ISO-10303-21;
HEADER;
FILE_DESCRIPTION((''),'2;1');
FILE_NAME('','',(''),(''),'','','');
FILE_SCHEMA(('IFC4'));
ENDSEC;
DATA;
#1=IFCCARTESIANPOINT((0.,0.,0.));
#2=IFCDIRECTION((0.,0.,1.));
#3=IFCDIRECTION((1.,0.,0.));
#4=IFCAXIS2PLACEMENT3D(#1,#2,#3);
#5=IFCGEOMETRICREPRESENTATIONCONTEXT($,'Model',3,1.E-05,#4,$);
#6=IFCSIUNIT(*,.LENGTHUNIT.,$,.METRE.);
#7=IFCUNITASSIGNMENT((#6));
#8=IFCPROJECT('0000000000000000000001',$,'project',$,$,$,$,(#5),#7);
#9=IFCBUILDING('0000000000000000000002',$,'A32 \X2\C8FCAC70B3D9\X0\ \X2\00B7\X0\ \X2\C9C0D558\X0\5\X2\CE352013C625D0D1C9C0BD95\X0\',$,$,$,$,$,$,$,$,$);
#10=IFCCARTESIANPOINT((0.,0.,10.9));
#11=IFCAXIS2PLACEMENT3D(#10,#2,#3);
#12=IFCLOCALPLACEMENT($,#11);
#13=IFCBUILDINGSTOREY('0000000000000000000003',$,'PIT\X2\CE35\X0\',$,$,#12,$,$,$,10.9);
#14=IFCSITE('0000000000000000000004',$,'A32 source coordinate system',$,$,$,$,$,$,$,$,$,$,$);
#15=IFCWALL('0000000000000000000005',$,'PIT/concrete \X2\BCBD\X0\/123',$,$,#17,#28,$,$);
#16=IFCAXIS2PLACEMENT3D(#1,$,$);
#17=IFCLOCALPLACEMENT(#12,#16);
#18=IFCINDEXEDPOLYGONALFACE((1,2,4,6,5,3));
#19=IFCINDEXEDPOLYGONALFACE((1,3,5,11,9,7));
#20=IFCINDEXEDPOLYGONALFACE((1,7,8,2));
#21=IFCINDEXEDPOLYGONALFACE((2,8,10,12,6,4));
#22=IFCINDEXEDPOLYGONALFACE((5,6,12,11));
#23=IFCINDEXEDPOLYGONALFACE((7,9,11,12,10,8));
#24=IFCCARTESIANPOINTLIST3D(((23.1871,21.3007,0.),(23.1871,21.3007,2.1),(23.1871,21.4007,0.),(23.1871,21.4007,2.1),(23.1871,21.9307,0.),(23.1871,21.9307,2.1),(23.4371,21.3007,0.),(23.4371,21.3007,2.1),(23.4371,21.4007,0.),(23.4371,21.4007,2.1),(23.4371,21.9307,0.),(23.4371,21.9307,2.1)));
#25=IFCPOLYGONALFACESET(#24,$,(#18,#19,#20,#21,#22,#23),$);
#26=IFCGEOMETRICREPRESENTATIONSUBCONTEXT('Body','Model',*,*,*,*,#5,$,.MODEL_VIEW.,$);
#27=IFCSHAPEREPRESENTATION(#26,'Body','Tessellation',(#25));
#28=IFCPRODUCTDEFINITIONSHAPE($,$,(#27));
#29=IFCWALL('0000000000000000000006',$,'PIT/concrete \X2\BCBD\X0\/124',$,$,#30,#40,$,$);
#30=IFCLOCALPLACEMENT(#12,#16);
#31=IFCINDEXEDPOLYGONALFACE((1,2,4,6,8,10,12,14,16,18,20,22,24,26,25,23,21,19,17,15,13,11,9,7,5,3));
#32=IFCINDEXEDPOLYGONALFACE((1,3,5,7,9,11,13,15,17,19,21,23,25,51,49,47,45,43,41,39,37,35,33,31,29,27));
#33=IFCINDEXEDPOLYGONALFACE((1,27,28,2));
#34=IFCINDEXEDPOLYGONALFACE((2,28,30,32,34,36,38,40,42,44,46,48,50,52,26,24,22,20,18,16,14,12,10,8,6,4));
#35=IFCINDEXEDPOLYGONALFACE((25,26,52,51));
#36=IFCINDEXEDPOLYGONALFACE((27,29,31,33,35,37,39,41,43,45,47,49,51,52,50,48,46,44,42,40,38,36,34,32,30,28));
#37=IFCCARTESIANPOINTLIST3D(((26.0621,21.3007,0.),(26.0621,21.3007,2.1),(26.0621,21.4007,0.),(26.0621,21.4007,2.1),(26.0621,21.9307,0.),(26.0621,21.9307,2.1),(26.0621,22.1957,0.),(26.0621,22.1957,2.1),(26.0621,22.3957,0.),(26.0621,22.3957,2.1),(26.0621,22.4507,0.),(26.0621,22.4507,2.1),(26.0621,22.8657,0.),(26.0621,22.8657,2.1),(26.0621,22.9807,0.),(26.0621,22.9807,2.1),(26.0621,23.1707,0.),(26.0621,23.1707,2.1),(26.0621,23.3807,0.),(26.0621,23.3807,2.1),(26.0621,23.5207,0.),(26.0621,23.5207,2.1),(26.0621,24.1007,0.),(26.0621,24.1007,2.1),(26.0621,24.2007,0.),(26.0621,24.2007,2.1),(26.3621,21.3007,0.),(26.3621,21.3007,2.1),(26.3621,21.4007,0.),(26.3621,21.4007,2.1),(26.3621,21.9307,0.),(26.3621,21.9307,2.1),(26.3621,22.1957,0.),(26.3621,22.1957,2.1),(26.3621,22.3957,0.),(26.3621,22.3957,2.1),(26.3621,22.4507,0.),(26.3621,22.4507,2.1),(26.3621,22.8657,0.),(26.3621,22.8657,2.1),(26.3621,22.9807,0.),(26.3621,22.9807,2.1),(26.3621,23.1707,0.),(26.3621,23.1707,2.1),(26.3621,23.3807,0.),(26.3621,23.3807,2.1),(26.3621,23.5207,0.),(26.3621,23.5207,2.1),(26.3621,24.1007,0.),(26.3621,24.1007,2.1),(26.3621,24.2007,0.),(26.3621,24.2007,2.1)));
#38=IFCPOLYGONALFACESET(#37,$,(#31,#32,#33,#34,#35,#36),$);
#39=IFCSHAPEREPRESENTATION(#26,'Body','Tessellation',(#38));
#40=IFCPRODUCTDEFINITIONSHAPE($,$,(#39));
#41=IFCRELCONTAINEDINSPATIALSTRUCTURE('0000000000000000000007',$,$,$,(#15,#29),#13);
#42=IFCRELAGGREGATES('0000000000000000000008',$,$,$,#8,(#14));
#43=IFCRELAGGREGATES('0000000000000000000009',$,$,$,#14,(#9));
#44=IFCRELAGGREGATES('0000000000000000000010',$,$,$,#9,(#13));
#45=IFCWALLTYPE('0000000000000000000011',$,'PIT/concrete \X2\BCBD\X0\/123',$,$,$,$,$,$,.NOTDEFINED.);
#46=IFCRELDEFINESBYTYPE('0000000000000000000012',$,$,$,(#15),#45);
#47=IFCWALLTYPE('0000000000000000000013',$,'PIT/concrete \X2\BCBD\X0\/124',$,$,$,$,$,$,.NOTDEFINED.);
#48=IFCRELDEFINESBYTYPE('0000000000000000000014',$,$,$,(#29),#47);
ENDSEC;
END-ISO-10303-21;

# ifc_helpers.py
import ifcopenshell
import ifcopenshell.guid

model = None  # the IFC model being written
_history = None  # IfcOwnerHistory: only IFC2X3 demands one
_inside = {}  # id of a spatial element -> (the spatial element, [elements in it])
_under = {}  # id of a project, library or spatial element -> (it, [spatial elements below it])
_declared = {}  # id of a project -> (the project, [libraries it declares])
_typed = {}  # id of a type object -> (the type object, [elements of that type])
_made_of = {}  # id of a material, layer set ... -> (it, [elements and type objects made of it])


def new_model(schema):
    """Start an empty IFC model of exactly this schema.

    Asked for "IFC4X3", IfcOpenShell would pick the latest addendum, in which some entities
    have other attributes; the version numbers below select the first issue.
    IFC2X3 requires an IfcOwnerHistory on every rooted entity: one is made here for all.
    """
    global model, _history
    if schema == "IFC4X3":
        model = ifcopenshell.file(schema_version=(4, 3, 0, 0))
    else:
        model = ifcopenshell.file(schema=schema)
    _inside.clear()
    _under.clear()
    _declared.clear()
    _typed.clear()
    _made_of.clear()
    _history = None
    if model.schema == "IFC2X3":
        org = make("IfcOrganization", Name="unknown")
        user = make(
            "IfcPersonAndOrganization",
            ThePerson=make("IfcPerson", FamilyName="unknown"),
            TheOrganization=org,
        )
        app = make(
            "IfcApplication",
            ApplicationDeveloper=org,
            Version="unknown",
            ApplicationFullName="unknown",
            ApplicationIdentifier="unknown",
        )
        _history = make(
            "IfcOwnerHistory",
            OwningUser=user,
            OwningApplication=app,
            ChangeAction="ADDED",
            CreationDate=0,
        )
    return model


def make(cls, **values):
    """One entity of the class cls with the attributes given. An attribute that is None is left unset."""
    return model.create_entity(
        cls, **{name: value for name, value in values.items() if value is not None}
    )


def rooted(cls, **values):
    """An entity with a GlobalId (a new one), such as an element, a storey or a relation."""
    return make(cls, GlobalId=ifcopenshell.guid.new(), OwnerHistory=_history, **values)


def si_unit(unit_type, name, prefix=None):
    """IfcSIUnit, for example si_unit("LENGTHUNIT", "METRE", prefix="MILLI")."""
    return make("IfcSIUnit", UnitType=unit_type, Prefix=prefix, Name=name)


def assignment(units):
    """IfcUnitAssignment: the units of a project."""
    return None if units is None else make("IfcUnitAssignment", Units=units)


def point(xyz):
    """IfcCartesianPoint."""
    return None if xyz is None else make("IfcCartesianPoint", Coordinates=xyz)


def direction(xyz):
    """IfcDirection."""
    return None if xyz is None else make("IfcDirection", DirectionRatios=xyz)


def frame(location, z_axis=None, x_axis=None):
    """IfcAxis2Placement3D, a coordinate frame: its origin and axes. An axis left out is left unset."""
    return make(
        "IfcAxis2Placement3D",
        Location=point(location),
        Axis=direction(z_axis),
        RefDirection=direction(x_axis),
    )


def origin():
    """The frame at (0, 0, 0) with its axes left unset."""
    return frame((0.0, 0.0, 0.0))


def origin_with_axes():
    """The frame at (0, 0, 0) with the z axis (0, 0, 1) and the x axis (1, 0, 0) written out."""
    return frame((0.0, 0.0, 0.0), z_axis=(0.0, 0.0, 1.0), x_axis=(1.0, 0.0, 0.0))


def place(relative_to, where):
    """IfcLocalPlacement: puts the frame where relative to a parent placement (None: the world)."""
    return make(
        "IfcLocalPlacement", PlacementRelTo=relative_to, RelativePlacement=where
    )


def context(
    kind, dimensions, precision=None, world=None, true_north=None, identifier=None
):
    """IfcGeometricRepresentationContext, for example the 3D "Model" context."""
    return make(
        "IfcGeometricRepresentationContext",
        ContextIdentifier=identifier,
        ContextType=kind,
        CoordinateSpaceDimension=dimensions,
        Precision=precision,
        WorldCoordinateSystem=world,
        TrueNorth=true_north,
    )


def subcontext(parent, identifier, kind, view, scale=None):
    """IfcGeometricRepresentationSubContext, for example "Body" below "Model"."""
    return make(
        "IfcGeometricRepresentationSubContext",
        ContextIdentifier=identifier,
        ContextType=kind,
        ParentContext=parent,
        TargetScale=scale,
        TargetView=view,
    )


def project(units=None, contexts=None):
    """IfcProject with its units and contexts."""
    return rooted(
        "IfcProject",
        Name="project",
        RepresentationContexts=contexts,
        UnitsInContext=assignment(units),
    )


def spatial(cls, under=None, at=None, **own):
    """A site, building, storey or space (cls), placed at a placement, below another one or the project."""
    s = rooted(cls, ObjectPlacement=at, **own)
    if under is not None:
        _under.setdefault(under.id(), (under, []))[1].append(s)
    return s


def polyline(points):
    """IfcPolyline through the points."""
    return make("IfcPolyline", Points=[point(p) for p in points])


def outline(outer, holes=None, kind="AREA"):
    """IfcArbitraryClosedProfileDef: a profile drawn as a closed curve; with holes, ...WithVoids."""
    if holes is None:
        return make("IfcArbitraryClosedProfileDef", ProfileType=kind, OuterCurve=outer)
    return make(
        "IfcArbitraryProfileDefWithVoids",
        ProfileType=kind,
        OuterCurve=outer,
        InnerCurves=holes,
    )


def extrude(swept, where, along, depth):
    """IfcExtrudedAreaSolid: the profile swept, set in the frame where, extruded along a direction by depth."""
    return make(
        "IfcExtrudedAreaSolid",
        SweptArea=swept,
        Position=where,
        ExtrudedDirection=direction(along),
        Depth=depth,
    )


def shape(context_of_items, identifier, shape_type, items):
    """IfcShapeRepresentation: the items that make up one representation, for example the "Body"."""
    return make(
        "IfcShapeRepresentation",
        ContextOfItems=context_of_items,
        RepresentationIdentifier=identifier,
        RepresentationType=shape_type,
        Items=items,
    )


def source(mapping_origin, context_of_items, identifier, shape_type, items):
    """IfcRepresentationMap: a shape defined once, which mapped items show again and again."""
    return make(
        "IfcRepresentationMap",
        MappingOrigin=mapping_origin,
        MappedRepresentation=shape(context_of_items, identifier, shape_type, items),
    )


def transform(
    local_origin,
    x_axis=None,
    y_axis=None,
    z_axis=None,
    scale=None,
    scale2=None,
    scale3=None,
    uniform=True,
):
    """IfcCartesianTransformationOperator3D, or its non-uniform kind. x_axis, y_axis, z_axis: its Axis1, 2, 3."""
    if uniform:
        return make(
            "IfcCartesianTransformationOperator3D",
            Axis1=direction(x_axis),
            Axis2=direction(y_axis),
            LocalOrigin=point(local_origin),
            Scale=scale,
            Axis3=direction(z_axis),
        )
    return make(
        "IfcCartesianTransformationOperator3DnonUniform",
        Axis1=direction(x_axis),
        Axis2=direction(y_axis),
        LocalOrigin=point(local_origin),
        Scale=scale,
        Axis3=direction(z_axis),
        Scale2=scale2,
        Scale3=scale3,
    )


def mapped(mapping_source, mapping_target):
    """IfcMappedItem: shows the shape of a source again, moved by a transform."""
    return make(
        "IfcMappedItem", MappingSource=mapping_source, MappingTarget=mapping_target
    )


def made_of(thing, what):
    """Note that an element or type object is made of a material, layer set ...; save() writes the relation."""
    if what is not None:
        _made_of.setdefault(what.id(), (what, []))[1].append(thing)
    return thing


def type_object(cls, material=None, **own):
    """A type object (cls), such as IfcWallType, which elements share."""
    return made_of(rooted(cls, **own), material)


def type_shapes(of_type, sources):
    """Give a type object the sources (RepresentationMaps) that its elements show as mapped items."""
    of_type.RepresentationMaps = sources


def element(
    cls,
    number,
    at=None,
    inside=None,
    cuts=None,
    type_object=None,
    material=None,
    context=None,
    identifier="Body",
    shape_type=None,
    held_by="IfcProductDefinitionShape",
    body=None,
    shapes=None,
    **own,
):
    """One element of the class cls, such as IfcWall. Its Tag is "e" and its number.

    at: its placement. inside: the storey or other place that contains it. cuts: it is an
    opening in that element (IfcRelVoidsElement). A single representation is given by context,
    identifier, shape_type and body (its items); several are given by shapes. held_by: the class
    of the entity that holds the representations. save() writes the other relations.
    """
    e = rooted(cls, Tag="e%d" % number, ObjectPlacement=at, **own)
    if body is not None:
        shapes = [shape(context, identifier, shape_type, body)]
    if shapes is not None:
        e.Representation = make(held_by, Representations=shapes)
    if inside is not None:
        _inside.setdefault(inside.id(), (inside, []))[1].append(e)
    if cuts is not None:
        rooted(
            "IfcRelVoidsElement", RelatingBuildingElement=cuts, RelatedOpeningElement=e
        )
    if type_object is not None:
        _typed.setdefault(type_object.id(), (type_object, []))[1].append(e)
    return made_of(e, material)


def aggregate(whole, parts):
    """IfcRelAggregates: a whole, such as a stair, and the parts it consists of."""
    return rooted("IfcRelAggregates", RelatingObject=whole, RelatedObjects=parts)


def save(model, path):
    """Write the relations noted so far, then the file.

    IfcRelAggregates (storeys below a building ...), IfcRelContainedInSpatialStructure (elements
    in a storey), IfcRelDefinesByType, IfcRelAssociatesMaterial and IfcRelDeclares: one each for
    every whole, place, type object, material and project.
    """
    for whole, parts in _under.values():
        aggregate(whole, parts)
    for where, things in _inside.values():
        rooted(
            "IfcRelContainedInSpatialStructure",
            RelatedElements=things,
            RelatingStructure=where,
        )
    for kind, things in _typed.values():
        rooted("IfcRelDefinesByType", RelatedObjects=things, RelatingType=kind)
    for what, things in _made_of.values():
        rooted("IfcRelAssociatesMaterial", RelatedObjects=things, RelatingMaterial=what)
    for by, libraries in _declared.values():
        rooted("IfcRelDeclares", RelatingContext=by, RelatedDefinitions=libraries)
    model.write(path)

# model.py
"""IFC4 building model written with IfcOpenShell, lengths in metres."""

from ifc_helpers import new_model, si_unit, frame, origin, origin_with_axes, place, context, subcontext, project, spatial, polyline, outline, extrude, source, transform, mapped, type_object, type_shapes, element, save


model = new_model("IFC4")

# Units and contexts
model_context = context("Model", 3, precision=1e-05, world=origin_with_axes())
body_context = subcontext(model_context, "Body", "Model", "MODEL_VIEW")
ifc_project = project(units=[si_unit("LENGTHUNIT", "METRE")], contexts=[model_context])

# Site, building, storey
site = spatial("IfcSite", under=ifc_project, Name="A32 source coordinate system")
building = spatial("IfcBuilding", under=site, Name="A32 주거동 · 지하5층–옥탑지붕")
storey_placement = place(None, frame((0.0, 0.0, 10.9), z_axis=(0.0, 0.0, 1.0), x_axis=(1.0, 0.0, 0.0)))
storey = spatial("IfcBuildingStorey", under=building, at=storey_placement, Name="PIT층", Elevation=10.9)

# Walls
wall_type_1 = type_object("IfcWallType", Name="PIT/concrete 벽/123", PredefinedType="NOTDEFINED")
shared_shape_1 = source(origin(), body_context, "Body", "SweptSolid", [
    extrude(outline(polyline([(23.1871, 21.9307), (23.4371, 21.9307), (23.4371, 21.4007), (23.4371, 21.3007), (23.1871, 21.3007), (23.1871, 21.4007), (23.1871, 21.9307)])), origin(), (0.0, 0.0, 1.0), 2.1),
])
type_shapes(wall_type_1, [shared_shape_1])
wall_1_placement = place(storey_placement, origin_with_axes())
element("IfcWall", 1, at=wall_1_placement, inside=storey, type_object=wall_type_1, Name="PIT/concrete 벽/123", context=body_context, shape_type="MappedRepresentation", body=[
    mapped(shared_shape_1, transform((0.0, 0.0, 0.0), scale=1.0)),
])
wall_type_2 = type_object("IfcWallType", Name="PIT/concrete 벽/124", PredefinedType="NOTDEFINED")
shared_shape_2 = source(origin(), body_context, "Body", "SweptSolid", [
    extrude(outline(polyline([(26.0621, 22.1957), (26.0621, 22.3957), (26.0621, 22.4507), (26.0621, 22.8657), (26.0621, 22.9807), (26.0621, 23.1707), (26.0621, 23.3807), (26.0621, 23.5207), (26.0621, 24.1007), (26.0621, 24.2007), (26.3621, 24.2007), (26.3621, 24.1007), (26.3621, 23.5207), (26.3621, 23.3807), (26.3621, 23.1707), (26.3621, 22.9807), (26.3621, 22.8657), (26.3621, 22.4507), (26.3621, 22.3957), (26.3621, 22.1957), (26.3621, 21.9307), (26.3621, 21.4007), (26.3621, 21.3007), (26.0621, 21.3007), (26.0621, 21.4007), (26.0621, 21.9307), (26.0621, 22.1957)])), origin(), (0.0, 0.0, 1.0), 2.1),
])
type_shapes(wall_type_2, [shared_shape_2])
wall_2_placement = place(storey_placement, origin_with_axes())
element("IfcWall", 2, at=wall_2_placement, inside=storey, type_object=wall_type_2, Name="PIT/concrete 벽/124", context=body_context, shape_type="MappedRepresentation", body=[
    mapped(shared_shape_2, transform((0.0, 0.0, 0.0), scale=1.0)),
])

save(model, "model.ifc")
